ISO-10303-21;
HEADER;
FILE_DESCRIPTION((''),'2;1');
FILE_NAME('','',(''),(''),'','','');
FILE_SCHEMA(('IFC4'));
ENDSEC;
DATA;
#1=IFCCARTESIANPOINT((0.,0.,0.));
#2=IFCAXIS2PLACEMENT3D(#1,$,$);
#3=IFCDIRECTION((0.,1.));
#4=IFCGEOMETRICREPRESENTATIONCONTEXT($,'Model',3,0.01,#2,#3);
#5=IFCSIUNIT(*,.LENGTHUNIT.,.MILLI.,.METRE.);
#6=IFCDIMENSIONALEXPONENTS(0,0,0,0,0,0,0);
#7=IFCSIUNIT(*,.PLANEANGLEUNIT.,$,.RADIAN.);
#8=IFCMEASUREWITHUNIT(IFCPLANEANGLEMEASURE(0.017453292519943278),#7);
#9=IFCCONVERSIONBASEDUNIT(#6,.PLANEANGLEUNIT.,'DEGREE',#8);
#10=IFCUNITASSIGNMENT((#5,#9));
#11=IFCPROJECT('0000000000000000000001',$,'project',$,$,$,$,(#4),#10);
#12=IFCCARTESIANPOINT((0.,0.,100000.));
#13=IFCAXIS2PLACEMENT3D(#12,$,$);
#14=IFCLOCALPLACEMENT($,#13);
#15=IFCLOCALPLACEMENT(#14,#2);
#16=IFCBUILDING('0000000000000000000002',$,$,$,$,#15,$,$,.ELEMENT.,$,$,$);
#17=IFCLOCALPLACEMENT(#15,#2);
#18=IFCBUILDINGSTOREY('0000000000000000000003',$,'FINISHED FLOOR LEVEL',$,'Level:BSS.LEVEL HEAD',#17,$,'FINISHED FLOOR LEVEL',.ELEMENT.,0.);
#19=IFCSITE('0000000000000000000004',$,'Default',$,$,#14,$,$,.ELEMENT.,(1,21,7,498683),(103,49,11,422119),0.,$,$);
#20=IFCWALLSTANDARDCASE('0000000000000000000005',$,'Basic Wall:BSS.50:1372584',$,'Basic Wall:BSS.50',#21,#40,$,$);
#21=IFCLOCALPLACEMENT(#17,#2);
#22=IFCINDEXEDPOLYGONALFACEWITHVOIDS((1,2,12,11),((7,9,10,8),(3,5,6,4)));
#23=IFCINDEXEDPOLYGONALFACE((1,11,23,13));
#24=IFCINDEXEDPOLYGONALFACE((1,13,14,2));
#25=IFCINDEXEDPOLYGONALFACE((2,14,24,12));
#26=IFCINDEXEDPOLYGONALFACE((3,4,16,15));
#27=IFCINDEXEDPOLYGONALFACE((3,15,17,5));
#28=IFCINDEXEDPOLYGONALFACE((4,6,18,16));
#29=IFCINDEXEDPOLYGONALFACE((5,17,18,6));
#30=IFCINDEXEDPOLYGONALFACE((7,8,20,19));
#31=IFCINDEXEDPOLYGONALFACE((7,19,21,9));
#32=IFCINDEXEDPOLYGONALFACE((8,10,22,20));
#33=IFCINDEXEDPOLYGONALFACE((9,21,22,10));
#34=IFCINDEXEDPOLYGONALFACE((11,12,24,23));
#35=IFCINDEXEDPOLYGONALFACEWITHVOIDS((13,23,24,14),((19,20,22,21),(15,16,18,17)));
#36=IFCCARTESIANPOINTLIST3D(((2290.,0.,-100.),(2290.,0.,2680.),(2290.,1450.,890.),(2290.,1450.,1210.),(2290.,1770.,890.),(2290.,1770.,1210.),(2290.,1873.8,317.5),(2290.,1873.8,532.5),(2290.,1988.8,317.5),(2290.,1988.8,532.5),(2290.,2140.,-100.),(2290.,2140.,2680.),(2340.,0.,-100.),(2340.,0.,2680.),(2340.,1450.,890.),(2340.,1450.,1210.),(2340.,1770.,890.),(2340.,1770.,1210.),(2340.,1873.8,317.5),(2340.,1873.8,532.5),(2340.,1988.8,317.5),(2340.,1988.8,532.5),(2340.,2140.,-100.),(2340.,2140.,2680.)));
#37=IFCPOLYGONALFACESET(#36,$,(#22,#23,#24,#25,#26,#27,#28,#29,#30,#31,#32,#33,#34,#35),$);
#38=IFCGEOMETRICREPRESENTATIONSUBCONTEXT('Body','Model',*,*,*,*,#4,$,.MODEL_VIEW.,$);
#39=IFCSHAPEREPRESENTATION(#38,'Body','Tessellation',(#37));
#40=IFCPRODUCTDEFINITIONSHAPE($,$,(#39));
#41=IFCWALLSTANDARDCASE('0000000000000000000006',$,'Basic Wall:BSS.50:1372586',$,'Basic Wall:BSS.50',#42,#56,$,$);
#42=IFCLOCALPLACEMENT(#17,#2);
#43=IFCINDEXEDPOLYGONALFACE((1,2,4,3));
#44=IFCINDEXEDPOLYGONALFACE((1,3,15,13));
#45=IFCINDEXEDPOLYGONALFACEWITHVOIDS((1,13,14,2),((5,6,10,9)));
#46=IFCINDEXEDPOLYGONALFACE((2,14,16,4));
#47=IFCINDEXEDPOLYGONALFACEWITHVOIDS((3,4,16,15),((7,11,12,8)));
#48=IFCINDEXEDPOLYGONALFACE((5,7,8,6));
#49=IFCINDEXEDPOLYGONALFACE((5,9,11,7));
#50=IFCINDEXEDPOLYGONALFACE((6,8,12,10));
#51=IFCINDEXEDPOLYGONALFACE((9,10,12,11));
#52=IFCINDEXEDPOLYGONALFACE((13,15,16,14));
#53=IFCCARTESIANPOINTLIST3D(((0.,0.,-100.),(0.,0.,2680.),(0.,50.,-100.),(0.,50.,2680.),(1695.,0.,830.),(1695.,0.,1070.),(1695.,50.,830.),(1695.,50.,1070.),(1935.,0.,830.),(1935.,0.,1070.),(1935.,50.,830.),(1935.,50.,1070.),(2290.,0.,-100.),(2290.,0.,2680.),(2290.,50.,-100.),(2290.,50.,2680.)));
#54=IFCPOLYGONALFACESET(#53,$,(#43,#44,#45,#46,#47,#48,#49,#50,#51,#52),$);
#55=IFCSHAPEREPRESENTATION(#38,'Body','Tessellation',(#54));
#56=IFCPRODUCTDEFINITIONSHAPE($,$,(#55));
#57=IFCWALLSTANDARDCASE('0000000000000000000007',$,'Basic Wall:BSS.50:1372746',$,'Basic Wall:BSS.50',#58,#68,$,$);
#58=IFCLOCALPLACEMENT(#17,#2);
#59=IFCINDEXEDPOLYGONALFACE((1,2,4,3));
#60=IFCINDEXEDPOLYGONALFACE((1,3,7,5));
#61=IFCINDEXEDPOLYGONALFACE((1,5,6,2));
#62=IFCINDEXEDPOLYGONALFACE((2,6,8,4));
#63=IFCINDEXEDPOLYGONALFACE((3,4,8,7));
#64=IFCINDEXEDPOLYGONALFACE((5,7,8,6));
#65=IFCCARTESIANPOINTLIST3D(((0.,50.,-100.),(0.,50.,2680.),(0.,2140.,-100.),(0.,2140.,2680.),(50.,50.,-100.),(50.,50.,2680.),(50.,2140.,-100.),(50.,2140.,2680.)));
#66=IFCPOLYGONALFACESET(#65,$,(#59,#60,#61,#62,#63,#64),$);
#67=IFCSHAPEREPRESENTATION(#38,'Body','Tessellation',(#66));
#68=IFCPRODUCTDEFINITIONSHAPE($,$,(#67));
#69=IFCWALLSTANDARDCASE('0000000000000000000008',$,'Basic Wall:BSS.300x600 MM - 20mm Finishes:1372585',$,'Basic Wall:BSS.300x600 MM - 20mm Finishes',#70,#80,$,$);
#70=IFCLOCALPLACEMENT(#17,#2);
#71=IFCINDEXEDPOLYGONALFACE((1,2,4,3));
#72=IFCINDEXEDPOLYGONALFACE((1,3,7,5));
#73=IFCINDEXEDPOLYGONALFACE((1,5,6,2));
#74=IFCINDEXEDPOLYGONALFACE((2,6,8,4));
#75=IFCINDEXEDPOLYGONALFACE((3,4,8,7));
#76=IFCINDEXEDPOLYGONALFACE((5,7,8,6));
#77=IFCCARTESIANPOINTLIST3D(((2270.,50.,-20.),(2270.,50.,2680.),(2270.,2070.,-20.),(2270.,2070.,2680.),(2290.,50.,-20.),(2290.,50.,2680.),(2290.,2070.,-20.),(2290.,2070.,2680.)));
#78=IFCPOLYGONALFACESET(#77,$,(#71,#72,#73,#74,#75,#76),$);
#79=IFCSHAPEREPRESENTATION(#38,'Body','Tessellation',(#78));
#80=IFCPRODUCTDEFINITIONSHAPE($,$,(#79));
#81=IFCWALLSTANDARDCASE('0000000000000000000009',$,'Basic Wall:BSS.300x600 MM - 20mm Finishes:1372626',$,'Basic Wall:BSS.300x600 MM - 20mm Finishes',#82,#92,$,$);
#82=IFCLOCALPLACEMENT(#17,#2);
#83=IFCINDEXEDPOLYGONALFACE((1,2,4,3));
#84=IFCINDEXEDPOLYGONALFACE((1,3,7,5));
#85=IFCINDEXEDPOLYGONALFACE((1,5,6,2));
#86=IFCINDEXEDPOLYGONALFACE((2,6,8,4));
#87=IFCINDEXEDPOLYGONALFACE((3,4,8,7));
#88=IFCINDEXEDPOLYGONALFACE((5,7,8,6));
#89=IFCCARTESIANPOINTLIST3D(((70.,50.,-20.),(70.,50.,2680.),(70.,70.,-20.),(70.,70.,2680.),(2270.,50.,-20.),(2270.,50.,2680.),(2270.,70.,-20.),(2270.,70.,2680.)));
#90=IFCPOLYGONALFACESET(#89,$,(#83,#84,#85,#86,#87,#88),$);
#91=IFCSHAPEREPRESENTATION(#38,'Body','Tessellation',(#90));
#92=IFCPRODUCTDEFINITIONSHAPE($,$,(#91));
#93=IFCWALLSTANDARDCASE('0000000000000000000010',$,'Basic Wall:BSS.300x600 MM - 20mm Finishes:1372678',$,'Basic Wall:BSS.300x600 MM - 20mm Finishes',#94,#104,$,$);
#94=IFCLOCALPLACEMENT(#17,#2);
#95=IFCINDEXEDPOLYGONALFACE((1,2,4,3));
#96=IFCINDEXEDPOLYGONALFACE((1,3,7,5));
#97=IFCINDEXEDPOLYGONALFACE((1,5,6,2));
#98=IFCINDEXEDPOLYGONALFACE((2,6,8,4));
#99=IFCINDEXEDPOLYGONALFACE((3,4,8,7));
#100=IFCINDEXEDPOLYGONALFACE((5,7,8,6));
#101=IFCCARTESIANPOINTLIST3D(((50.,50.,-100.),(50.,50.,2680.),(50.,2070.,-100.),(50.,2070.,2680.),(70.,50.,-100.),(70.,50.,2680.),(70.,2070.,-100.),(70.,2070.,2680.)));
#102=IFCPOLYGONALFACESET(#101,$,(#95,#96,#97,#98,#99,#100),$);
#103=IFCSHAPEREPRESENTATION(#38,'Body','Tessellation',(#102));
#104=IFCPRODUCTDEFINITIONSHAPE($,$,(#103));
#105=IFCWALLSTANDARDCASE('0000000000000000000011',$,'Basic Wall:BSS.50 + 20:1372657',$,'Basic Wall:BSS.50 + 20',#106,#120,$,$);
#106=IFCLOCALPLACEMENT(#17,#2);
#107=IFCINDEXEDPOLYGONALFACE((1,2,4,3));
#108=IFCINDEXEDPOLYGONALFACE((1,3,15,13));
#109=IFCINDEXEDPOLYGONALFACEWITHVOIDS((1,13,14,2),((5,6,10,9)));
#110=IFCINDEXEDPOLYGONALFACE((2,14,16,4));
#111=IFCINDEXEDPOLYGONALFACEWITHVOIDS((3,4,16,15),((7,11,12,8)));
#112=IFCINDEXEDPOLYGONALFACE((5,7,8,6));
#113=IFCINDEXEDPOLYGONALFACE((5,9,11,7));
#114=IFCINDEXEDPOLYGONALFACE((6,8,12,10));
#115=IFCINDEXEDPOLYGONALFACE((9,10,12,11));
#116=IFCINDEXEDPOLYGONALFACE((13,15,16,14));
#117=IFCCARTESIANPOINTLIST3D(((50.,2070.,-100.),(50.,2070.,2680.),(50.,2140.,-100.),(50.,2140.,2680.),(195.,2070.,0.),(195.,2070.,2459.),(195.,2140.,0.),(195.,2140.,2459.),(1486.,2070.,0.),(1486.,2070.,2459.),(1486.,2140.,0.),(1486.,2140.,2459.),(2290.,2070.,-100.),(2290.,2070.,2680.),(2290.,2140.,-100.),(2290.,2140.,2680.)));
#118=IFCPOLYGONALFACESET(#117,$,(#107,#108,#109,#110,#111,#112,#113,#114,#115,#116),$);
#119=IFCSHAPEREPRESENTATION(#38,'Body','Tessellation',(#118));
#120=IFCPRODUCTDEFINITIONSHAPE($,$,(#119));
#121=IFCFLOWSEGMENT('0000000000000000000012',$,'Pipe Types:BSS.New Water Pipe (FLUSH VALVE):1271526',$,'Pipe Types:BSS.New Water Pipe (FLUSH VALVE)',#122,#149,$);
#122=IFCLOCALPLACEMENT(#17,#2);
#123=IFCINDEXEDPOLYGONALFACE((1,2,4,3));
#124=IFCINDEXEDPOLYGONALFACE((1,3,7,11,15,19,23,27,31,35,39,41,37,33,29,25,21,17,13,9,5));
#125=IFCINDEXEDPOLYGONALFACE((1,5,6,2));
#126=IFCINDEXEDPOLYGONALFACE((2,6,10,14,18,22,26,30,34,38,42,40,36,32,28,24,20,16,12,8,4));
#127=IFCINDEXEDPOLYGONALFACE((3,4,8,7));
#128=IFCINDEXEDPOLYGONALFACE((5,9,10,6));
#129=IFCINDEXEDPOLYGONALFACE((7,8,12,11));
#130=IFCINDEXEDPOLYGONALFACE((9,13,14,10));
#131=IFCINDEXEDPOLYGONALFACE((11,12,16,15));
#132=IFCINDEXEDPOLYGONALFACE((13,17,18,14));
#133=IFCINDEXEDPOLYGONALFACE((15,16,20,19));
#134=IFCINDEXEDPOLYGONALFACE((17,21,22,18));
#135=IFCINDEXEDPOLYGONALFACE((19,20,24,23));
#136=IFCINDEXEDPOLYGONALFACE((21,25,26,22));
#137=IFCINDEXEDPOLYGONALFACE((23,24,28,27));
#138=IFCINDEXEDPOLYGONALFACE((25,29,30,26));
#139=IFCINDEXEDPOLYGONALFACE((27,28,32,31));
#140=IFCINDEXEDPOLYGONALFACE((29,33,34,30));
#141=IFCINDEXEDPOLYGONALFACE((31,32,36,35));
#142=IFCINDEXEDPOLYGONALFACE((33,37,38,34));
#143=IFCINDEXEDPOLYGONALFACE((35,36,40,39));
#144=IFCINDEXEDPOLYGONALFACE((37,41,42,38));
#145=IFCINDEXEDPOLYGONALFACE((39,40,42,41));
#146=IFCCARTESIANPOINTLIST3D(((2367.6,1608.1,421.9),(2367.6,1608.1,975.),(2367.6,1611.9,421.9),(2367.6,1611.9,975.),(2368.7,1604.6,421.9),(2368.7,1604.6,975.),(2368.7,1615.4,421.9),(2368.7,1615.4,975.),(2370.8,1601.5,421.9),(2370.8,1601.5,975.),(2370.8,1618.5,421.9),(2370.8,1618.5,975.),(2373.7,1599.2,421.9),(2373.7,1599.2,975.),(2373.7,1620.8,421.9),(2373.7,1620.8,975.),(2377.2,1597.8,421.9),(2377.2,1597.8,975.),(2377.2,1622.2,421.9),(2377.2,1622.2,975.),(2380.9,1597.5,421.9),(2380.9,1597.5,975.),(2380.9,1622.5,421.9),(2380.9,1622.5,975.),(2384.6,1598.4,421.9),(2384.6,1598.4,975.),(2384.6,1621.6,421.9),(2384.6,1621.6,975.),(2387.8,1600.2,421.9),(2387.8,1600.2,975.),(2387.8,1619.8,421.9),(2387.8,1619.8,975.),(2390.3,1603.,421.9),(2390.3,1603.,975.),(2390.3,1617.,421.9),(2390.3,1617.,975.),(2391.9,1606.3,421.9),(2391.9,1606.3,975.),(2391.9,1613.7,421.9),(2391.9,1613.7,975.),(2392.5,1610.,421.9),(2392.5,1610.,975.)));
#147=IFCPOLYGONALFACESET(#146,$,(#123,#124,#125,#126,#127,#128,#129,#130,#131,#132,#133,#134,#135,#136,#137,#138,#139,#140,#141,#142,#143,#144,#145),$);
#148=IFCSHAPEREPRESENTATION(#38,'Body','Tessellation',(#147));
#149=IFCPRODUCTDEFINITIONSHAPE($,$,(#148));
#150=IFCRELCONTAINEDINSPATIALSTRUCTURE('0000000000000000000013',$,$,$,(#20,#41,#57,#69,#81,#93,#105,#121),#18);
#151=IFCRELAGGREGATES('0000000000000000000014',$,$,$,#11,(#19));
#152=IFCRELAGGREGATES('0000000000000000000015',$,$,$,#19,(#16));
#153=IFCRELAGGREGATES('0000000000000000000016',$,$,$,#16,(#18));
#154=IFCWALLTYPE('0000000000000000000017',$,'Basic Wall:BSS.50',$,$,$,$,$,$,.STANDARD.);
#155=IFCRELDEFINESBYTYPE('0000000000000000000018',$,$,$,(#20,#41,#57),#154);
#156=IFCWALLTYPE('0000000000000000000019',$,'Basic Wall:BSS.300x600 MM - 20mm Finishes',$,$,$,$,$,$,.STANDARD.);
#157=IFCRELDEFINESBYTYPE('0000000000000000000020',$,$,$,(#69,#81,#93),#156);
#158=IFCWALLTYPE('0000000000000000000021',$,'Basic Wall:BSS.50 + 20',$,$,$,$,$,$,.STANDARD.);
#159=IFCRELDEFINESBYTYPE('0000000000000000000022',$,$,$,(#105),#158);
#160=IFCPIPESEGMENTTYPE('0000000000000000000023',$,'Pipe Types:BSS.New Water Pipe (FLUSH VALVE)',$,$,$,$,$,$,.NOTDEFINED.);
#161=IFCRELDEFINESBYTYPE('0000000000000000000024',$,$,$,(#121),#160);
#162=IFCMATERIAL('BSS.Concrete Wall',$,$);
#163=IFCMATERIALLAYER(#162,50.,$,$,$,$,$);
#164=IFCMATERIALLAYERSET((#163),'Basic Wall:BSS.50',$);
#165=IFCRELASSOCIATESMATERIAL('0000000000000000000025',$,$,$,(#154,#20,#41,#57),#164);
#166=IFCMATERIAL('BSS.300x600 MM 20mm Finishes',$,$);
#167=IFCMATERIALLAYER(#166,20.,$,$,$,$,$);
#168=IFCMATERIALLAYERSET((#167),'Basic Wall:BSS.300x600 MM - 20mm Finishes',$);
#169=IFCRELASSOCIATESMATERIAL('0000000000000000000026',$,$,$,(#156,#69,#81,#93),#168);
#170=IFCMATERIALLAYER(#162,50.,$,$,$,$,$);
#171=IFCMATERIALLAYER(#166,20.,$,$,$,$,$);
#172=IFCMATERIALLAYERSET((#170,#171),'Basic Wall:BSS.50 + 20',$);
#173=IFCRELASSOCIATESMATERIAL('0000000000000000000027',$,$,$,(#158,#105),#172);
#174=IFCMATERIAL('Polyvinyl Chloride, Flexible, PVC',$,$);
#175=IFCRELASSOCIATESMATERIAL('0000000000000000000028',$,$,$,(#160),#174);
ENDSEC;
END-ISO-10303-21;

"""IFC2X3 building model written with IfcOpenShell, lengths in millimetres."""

from ifc_helpers import new_model, entity, si_unit, converted_unit, direction, frame, frame_2d, origin, origin_2d_with_axis, place, context, subcontext, project, spatial, rectangle, circle, extrude, material, layer, layer_set, layer_usage, type_object, element, save


model = new_model("IFC2X3")

# Units and contexts
model_context = context("Model", 3, precision=0.01, world=origin(), true_north=direction((0.0, 1.0)))
body_context = subcontext(model_context, "Body", "Model", "MODEL_VIEW")
ifc_project = project(units=[si_unit("LENGTHUNIT", "METRE", prefix="MILLI"), converted_unit("PLANEANGLEUNIT", "DEGREE", entity("IfcPlaneAngleMeasure", 0.017453292519943278), si_unit("PLANEANGLEUNIT", "RADIAN"), dimensions=[0, 0, 0, 0, 0, 0, 0])], contexts=[model_context])

# Site, building, storey
site_placement = place(None, frame((0.0, 0.0, 100000.0)))
site = spatial("IfcSite", under=ifc_project, at=site_placement, Name="Default", CompositionType="ELEMENT", RefLatitude=(1, 21, 7, 498683), RefLongitude=(103, 49, 11, 422119), RefElevation=0.0)
building_placement = place(site_placement, origin())
building = spatial("IfcBuilding", under=site, at=building_placement, CompositionType="ELEMENT")
storey_placement = place(building_placement, origin())
storey = spatial("IfcBuildingStorey", under=building, at=storey_placement, Name="FINISHED FLOOR LEVEL", ObjectType="Level:BSS.LEVEL HEAD", LongName="FINISHED FLOOR LEVEL", CompositionType="ELEMENT", Elevation=0.0)

# Wall, openings
ifc_material_1 = material(Name="BSS.Concrete Wall")
ifc_layer_1 = layer(ifc_material_1, 50.0)
ifc_layer_set_1 = layer_set([ifc_layer_1], Name="Basic Wall:BSS.50")
ifc_layer_usage_1 = layer_usage(ifc_layer_set_1, "AXIS2", "POSITIVE", -25.0)
wall_type_1 = type_object("IfcWallType", Name="Basic Wall:BSS.50", PredefinedType="STANDARD", material=ifc_layer_set_1)
wall_1_placement = place(storey_placement, frame((2315.0, 2140.0, -100.0), z_axis=(0.0, 0.0, 1.0), x_axis=(0.0, -1.0, 0.0)))
wall_1 = element("IfcWallStandardCase", 1, at=wall_1_placement, inside=storey, type_object=wall_type_1, material=ifc_layer_usage_1, Name="Basic Wall:BSS.50:1372584", ObjectType="Basic Wall:BSS.50", context=body_context, shape_type="SweptSolid", body=[
    extrude(rectangle(XDim=2140.0, YDim=50.0, at=frame_2d((1070.0, 0.0), x_axis=(-1.0, 0.0))), origin(), (0.0, 0.0, 1.0), 2780.0),
])
opening_1_placement = place(wall_1_placement, origin())
element("IfcOpeningElement", 2, at=opening_1_placement, cuts=wall_1, ObjectType="Opening", context=body_context, shape_type="SweptSolid", body=[
    extrude(rectangle(XDim=215.0, YDim=115.0, at=origin_2d_with_axis()), frame((208.7, -25.0, 525.0), z_axis=(0.0, 1.0, 0.0), x_axis=(0.0, 0.0, -1.0)), (0.0, 0.0, 1.0), 50.0),
])
opening_2_placement = place(wall_1_placement, frame((2140.0, -2315.0, 100.0), z_axis=(0.0, 0.0, 1.0), x_axis=(0.0, 1.0, 0.0)))
element("IfcOpeningElement", 3, at=opening_2_placement, cuts=wall_1, ObjectType="Opening", context=body_context, shape_type="SweptSolid", body=[
    extrude(rectangle(XDim=320.0, YDim=320.0, at=frame_2d((0.0, 0.0), x_axis=(1.0, 0.0))), frame((816.0, 1610.0, 1050.0), z_axis=(1.0, 0.0, 0.0), x_axis=(0.0, 0.0, -1.0)), (0.0, 0.0, 1.0), 3048.0),
])

# Wall, opening
ifc_layer_usage_2 = layer_usage(ifc_layer_set_1, "AXIS2", "NEGATIVE", 25.0)
wall_2_placement = place(storey_placement, frame((2290.0, 25.0, -100.0), z_axis=(0.0, 0.0, 1.0), x_axis=(-1.0, 0.0, 0.0)))
wall_2 = element("IfcWallStandardCase", 4, at=wall_2_placement, inside=storey, type_object=wall_type_1, material=ifc_layer_usage_2, Name="Basic Wall:BSS.50:1372586", ObjectType="Basic Wall:BSS.50", context=body_context, shape_type="SweptSolid", body=[
    extrude(rectangle(XDim=2290.0, YDim=50.0, at=frame_2d((1145.0, 0.0), x_axis=(-1.0, 0.0))), origin(), (0.0, 0.0, 1.0), 2780.0),
])
opening_3_placement = place(wall_2_placement, origin())
element("IfcOpeningElement", 5, at=opening_3_placement, cuts=wall_2, ObjectType="Opening", context=body_context, shape_type="SweptSolid", body=[
    extrude(rectangle(XDim=240.0, YDim=240.0, at=frame_2d((0.0, 0.0), x_axis=(1.0, 0.0))), frame((475.0, -25.0, 1050.0), z_axis=(0.0, 1.0, 0.0), x_axis=(0.0, 0.0, -1.0)), (0.0, 0.0, 1.0), 50.0),
])

# Walls
ifc_layer_usage_3 = layer_usage(ifc_layer_set_1, "AXIS2", "NEGATIVE", 25.0)
wall_3_placement = place(storey_placement, frame((25.0, 50.0, -100.0), z_axis=(0.0, 0.0, 1.0), x_axis=(0.0, 1.0, 0.0)))
element("IfcWallStandardCase", 6, at=wall_3_placement, inside=storey, type_object=wall_type_1, material=ifc_layer_usage_3, Name="Basic Wall:BSS.50:1372746", ObjectType="Basic Wall:BSS.50", context=body_context, shape_type="SweptSolid", body=[
    extrude(rectangle(XDim=2090.0, YDim=50.0, at=frame_2d((1045.0, 0.0), x_axis=(-1.0, 0.0))), origin(), (0.0, 0.0, 1.0), 2780.0),
])
ifc_material_2 = material(Name="BSS.300x600 MM 20mm Finishes")
ifc_layer_2 = layer(ifc_material_2, 20.0)
ifc_layer_set_2 = layer_set([ifc_layer_2], Name="Basic Wall:BSS.300x600 MM - 20mm Finishes")
ifc_layer_usage_4 = layer_usage(ifc_layer_set_2, "AXIS2", "NEGATIVE", 10.0)
wall_type_2 = type_object("IfcWallType", Name="Basic Wall:BSS.300x600 MM - 20mm Finishes", PredefinedType="STANDARD", material=ifc_layer_set_2)
wall_4_placement = place(storey_placement, frame((2280.0, 2070.0, -20.0), z_axis=(0.0, 0.0, 1.0), x_axis=(0.0, -1.0, 0.0)))
element("IfcWallStandardCase", 7, at=wall_4_placement, inside=storey, type_object=wall_type_2, material=ifc_layer_usage_4, Name="Basic Wall:BSS.300x600 MM - 20mm Finishes:1372585", ObjectType="Basic Wall:BSS.300x600 MM - 20mm Finishes", context=body_context, shape_type="SweptSolid", body=[
    extrude(rectangle(XDim=2020.0, YDim=20.0, at=frame_2d((1010.0, 0.0), x_axis=(-1.0, 0.0))), origin(), (0.0, 0.0, 1.0), 2700.0),
])
ifc_layer_usage_5 = layer_usage(ifc_layer_set_2, "AXIS2", "NEGATIVE", 10.0)
wall_5_placement = place(storey_placement, frame((2270.0, 60.0, -20.0), z_axis=(0.0, 0.0, 1.0), x_axis=(-1.0, 0.0, 0.0)))
element("IfcWallStandardCase", 8, at=wall_5_placement, inside=storey, type_object=wall_type_2, material=ifc_layer_usage_5, Name="Basic Wall:BSS.300x600 MM - 20mm Finishes:1372626", ObjectType="Basic Wall:BSS.300x600 MM - 20mm Finishes", context=body_context, shape_type="SweptSolid", body=[
    extrude(rectangle(XDim=2200.0, YDim=20.0, at=frame_2d((1100.0, 0.0), x_axis=(-1.0, 0.0))), origin(), (0.0, 0.0, 1.0), 2700.0),
])
ifc_layer_usage_6 = layer_usage(ifc_layer_set_2, "AXIS2", "NEGATIVE", 10.0)
wall_6_placement = place(storey_placement, frame((60.0, 50.0, -100.0), z_axis=(0.0, 0.0, 1.0), x_axis=(0.0, 1.0, 0.0)))
element("IfcWallStandardCase", 9, at=wall_6_placement, inside=storey, type_object=wall_type_2, material=ifc_layer_usage_6, Name="Basic Wall:BSS.300x600 MM - 20mm Finishes:1372678", ObjectType="Basic Wall:BSS.300x600 MM - 20mm Finishes", context=body_context, shape_type="SweptSolid", body=[
    extrude(rectangle(XDim=2020.0, YDim=20.0, at=frame_2d((1010.0, 0.0), x_axis=(-1.0, 0.0))), origin(), (0.0, 0.0, 1.0), 2780.0),
])

# Wall, opening
ifc_layer_3 = layer(ifc_material_1, 50.0)
ifc_layer_4 = layer(ifc_material_2, 20.0)
ifc_layer_set_3 = layer_set([ifc_layer_3, ifc_layer_4], Name="Basic Wall:BSS.50 + 20")
ifc_layer_usage_7 = layer_usage(ifc_layer_set_3, "AXIS2", "NEGATIVE", 35.0)
wall_type_3 = type_object("IfcWallType", Name="Basic Wall:BSS.50 + 20", PredefinedType="STANDARD", material=ifc_layer_set_3)
wall_7_placement = place(storey_placement, frame((50.0, 2105.0, -100.0)))
wall_7 = element("IfcWallStandardCase", 10, at=wall_7_placement, inside=storey, type_object=wall_type_3, material=ifc_layer_usage_7, Name="Basic Wall:BSS.50 + 20:1372657", ObjectType="Basic Wall:BSS.50 + 20", context=body_context, shape_type="SweptSolid", body=[
    extrude(rectangle(XDim=2240.0, YDim=70.0, at=frame_2d((1120.0, 0.0), x_axis=(-1.0, 0.0))), origin(), (0.0, 0.0, 1.0), 2780.0),
])
opening_4_placement = place(wall_7_placement, frame((1436.0, 35.0, 100.0)))
element("IfcOpeningElement", 11, at=opening_4_placement, cuts=wall_7, ObjectType="Opening", context=body_context, shape_type="SweptSolid", body=[
    extrude(rectangle(XDim=2459.0, YDim=1291.0, at=frame_2d((1229.5, 645.5), x_axis=(1.0, 0.0))), frame((0.0, 0.0, 0.0), z_axis=(0.0, -1.0, 0.0), x_axis=(0.0, 0.0, 1.0)), (0.0, 0.0, 1.0), 70.0),
])

# Flow segment
ifc_material_3 = material(Name="Polyvinyl Chloride, Flexible, PVC")
pipe_segment_type_1 = type_object("IfcPipeSegmentType", Name="Pipe Types:BSS.New Water Pipe (FLUSH VALVE)", PredefinedType="NOTDEFINED", material=ifc_material_3)
flow_segment_1_placement = place(storey_placement, origin())
element("IfcFlowSegment", 12, at=flow_segment_1_placement, inside=storey, type_object=pipe_segment_type_1, Name="Pipe Types:BSS.New Water Pipe (FLUSH VALVE):1271526", ObjectType="Pipe Types:BSS.New Water Pipe (FLUSH VALVE)", context=body_context, shape_type="SweptSolid", body=[
    extrude(circle(Radius=12.5, at=origin_2d_with_axis()), frame((2380.0, 1610.0, 421.9)), (0.0, 0.0, 1.0), 553.1),
])

save(model, "model.ifc")
